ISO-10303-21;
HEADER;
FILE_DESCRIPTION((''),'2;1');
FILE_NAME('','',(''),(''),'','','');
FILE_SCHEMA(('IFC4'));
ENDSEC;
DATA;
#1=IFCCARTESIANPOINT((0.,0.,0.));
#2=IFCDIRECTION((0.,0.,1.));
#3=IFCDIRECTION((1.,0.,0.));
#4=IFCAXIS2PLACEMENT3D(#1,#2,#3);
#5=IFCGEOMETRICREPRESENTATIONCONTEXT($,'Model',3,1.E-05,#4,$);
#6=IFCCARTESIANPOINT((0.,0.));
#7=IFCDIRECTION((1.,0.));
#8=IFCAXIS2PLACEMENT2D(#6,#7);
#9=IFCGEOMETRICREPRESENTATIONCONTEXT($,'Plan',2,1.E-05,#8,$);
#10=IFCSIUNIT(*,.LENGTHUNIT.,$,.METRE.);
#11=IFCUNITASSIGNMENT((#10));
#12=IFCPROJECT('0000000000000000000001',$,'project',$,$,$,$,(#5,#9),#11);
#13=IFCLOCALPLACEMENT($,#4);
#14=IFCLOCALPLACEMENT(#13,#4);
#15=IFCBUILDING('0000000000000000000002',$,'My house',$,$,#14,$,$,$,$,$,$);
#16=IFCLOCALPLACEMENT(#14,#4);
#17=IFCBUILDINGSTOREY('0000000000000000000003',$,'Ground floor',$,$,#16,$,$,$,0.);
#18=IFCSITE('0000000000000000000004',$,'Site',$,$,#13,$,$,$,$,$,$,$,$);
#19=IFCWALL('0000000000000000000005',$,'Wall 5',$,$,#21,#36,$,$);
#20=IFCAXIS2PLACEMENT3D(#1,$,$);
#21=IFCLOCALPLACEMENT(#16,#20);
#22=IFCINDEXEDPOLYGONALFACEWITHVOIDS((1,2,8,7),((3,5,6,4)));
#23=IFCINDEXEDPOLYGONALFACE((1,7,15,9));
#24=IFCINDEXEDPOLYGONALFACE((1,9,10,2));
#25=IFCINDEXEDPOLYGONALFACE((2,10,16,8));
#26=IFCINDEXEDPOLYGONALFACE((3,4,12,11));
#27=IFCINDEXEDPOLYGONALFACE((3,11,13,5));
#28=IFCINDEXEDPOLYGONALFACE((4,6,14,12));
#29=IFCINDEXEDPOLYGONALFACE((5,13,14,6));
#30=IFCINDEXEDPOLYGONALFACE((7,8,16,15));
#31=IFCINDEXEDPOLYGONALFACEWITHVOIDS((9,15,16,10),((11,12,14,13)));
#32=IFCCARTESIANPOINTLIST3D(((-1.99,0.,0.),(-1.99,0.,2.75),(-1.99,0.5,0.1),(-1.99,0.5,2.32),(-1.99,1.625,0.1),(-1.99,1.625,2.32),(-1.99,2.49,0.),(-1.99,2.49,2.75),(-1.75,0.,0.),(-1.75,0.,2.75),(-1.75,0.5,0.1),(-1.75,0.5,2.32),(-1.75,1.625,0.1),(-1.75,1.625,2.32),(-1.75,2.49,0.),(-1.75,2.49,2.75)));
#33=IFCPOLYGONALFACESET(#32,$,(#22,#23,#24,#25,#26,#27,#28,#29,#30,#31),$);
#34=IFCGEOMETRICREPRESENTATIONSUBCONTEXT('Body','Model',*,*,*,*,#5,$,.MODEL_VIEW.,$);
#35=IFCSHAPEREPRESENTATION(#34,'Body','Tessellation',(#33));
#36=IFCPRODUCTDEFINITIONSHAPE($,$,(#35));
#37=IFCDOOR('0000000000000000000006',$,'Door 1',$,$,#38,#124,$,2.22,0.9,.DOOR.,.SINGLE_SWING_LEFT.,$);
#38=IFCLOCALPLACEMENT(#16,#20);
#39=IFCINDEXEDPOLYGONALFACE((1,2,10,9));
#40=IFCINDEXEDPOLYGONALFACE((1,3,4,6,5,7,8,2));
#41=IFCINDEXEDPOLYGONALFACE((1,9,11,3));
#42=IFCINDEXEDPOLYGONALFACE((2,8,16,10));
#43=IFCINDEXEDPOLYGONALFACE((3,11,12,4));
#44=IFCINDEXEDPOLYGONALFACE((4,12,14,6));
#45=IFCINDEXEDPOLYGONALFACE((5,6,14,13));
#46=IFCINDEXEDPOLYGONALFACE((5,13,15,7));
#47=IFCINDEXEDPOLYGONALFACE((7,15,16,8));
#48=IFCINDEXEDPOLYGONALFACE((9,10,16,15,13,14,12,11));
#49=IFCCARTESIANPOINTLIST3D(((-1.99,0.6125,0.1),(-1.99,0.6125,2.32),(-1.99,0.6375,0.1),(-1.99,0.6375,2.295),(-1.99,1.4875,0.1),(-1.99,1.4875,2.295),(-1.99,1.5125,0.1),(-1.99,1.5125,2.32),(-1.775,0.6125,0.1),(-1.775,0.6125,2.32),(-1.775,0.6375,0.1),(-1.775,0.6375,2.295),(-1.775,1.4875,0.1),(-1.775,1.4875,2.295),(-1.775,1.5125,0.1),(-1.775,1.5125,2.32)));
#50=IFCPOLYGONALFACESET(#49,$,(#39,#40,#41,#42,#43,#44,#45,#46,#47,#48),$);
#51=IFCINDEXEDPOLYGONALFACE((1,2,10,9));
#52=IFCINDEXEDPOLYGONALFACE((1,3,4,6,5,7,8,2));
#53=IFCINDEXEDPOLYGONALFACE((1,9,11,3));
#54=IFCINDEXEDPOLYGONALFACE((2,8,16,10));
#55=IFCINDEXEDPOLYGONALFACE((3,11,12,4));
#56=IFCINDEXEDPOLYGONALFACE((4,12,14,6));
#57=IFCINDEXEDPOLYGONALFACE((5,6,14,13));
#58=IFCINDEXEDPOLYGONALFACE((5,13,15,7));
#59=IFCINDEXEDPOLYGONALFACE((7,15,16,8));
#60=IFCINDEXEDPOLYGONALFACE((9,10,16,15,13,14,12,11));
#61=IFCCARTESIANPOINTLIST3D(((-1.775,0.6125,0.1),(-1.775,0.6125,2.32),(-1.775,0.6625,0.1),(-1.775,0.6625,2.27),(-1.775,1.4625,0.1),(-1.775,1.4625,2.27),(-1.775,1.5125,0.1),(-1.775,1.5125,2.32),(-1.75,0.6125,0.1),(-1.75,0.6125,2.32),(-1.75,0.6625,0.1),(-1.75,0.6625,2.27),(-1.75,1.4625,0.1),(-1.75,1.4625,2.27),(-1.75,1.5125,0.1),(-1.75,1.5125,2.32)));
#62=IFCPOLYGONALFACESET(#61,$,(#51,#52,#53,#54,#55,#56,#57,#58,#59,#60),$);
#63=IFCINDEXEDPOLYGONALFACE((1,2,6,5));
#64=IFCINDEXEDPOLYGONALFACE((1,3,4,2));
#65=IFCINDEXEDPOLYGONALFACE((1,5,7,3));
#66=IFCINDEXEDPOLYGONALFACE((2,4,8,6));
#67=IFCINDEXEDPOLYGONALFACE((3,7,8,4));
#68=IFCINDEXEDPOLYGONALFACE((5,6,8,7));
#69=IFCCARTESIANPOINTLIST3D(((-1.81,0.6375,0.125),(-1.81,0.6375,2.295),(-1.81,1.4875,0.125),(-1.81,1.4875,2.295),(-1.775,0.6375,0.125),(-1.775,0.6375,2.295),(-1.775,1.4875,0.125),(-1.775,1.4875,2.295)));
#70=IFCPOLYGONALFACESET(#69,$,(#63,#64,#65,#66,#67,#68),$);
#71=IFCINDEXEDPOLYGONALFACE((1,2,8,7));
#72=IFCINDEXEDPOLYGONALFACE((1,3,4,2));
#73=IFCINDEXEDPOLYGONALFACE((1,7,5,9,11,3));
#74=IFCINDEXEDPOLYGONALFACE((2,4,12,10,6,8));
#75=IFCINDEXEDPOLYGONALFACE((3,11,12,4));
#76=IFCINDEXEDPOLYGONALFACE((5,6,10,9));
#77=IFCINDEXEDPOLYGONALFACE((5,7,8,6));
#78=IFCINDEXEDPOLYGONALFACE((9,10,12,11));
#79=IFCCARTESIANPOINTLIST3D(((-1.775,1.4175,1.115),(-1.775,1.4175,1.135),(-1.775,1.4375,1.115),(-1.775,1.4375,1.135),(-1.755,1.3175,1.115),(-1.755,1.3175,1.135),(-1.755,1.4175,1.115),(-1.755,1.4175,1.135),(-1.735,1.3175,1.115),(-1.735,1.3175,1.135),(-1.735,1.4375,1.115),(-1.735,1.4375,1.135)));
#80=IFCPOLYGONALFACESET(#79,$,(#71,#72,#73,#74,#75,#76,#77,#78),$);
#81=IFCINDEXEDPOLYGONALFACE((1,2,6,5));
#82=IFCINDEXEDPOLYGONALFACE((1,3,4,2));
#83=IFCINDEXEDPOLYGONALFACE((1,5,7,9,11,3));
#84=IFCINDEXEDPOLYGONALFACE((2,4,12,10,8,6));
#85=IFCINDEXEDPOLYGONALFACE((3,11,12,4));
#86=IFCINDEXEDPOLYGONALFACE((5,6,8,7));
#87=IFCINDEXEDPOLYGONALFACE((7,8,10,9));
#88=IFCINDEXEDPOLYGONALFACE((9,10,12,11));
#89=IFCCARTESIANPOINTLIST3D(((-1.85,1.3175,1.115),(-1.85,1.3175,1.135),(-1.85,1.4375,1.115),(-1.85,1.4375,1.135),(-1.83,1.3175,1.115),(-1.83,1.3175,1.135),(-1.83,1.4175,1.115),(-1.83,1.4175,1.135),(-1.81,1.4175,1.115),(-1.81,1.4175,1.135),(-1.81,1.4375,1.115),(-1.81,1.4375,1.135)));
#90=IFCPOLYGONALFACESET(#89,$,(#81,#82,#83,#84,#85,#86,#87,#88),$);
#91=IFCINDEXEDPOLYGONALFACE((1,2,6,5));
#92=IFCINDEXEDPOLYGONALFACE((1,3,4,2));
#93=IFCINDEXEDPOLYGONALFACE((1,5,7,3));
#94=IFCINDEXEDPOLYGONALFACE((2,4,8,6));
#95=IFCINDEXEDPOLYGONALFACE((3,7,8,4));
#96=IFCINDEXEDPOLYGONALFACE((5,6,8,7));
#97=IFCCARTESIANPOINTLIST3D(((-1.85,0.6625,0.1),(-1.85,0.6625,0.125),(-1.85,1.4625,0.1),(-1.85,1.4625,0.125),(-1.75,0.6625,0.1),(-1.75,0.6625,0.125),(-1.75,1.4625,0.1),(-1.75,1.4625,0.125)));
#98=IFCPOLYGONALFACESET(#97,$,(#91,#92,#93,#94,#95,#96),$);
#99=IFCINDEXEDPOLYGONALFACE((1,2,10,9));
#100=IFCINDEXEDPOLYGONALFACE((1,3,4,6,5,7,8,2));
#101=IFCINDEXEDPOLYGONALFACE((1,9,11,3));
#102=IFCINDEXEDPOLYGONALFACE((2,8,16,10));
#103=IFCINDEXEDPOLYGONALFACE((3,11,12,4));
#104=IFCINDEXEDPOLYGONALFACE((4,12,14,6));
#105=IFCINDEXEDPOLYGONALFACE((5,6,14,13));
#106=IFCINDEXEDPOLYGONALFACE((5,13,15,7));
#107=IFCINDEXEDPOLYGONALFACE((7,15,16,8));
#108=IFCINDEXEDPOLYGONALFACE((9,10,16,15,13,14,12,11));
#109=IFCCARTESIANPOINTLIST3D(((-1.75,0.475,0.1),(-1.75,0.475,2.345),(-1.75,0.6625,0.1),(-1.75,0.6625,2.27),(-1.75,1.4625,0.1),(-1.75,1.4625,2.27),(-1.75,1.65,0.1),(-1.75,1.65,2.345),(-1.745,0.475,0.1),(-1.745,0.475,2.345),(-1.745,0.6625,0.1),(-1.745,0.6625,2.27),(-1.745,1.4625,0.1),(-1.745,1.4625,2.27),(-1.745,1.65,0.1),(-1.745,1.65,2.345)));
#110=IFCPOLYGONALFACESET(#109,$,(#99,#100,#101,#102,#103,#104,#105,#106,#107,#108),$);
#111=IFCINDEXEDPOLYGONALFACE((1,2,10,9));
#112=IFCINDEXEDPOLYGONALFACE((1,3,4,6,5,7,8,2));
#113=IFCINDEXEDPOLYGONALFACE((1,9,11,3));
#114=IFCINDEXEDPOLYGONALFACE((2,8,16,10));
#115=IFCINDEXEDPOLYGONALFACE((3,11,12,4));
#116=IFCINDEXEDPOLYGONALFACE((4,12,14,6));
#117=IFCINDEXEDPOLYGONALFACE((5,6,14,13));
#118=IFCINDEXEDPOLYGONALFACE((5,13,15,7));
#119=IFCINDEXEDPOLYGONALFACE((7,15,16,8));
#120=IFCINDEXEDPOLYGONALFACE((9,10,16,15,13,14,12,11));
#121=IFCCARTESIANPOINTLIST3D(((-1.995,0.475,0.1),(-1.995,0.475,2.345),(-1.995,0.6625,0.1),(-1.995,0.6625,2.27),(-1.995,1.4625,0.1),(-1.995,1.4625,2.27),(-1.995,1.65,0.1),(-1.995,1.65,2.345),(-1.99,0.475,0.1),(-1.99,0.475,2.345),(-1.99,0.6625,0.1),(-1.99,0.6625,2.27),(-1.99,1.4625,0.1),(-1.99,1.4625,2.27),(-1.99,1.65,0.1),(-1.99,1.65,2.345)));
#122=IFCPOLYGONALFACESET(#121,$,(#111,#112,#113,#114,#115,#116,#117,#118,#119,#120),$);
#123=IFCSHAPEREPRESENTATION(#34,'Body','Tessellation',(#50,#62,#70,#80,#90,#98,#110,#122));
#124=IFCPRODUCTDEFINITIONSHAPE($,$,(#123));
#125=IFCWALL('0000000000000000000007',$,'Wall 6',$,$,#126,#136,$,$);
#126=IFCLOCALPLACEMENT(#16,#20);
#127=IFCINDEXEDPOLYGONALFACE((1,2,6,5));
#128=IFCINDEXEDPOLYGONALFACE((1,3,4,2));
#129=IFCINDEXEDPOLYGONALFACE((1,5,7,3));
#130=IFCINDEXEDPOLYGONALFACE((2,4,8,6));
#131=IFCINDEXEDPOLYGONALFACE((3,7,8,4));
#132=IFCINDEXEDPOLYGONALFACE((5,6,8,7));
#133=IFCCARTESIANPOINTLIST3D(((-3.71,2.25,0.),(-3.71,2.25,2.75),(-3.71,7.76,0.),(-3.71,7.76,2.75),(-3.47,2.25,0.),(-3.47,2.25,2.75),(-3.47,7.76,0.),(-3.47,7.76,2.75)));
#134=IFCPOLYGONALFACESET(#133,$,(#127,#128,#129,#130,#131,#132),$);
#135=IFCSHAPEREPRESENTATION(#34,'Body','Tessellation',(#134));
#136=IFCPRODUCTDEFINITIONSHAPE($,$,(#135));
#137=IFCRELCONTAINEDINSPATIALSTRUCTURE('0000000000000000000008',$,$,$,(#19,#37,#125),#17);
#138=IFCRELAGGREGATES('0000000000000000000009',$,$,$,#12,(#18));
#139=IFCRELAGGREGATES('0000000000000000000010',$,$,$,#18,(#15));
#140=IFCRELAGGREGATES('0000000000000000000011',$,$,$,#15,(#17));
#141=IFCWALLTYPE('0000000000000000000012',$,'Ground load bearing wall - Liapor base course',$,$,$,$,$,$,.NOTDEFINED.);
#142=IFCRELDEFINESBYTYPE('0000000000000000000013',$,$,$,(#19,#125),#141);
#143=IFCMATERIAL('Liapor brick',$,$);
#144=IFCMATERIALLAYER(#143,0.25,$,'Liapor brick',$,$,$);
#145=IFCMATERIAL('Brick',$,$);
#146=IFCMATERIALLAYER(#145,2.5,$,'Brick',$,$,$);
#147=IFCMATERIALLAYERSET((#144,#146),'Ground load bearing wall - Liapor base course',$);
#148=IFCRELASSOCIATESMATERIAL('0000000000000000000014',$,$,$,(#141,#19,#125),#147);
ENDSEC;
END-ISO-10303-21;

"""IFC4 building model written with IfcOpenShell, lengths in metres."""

from ifc_helpers import new_model, entity, si_unit, frame, origin_with_axes, origin_2d_with_axis, place, context, subcontext, project, spatial, line, indexed_curve, outline, extrude, shape, source, transform, mapped, material, layer, layer_set, layer_usage, type_object, element, fill, save


model = new_model("IFC4")

# Units and contexts
model_context = context("Model", 3, precision=1e-05, world=origin_with_axes())
plan_context = context("Plan", 2, precision=1e-05, world=origin_2d_with_axis())
body_context_1 = subcontext(model_context, "Body", "Model", "MODEL_VIEW")
body_context_2 = subcontext(plan_context, "Body", "Plan", "PLAN_VIEW")
ifc_project = project(units=[si_unit("LENGTHUNIT", "METRE")], contexts=[model_context, plan_context])

# Site, building, storey
site_placement = place(None, origin_with_axes())
site = spatial("IfcSite", under=ifc_project, at=site_placement, Name="Site")
building_placement = place(site_placement, origin_with_axes())
building = spatial("IfcBuilding", under=site, at=building_placement, Name="My house")
storey_placement = place(building_placement, origin_with_axes())
storey = spatial("IfcBuildingStorey", under=building, at=storey_placement, Name="Ground floor", Elevation=0.0)

# Shared definitions
ifc_material_1 = material(Name="Liapor brick")
ifc_layer_1 = layer(ifc_material_1, 0.25, Name="Liapor brick")
ifc_material_2 = material(Name="Brick")
ifc_layer_2 = layer(ifc_material_2, 2.5, Name="Brick")
ifc_layer_set_1 = layer_set([ifc_layer_1, ifc_layer_2], Name="Ground load bearing wall - Liapor base course")
wall_type_1 = type_object("IfcWallType", Name="Ground load bearing wall - Liapor base course", PredefinedType="NOTDEFINED", material=ifc_layer_set_1)

# Wall, opening, door
ifc_layer_usage_1 = layer_usage(ifc_layer_set_1, "AXIS3", "POSITIVE", 0.0)
shared_shape_1 = source(origin_with_axes(), body_context_1, "Body", "SweptSolid", [
    extrude(outline(indexed_curve([(0.0, 0.0), (0.0, 0.24), (2.49, 0.24), (2.49, 0.0), (0.0, 0.0)], self_intersect=False)), origin_with_axes(), (0.0, 0.0, 1.0), 2.75),
])
wall_1_placement = place(storey_placement, frame((-1.75, 2.49, 0.0), z_axis=(0.0, 0.0, 1.0), x_axis=(0.0, 1.0, 0.0)))
wall_1 = element("IfcWall", 1, at=wall_1_placement, inside=storey, type_object=wall_type_1, material=ifc_layer_usage_1, Name="Wall 5", context=body_context_1, shape_type="MappedRepresentation", body=[
    mapped(shared_shape_1, transform((0.0, 0.0, 0.0), x_axis=(-1.0, 0.0, 0.0), y_axis=(0.0, 1.0, 0.0), z_axis=(0.0, 0.0, 1.0), scale=1.0)),
])
shared_shape_2 = source(origin_with_axes(), body_context_1, "Body", "SweptSolid", [
    extrude(outline(indexed_curve([(0.0, 0.0), (0.0, 0.34), (1.125, 0.34), (1.125, 0.0), (0.0, 0.0)], self_intersect=False)), frame((0.0, -0.05, 0.0), z_axis=(0.0, 0.0, 1.0), x_axis=(1.0, 0.0, 0.0)), (0.0, 0.0, 1.0), 2.22),
])
opening_1_placement = place(wall_1_placement, frame((-0.865, 0.0, 0.1), z_axis=(0.0, 0.0, 1.0), x_axis=(1.0, 0.0, 0.0)))
opening_1 = element("IfcOpeningElement", 2, at=opening_1_placement, cuts=wall_1, PredefinedType="OPENING", context=body_context_1, shape_type="MappedRepresentation", body=[
    mapped(shared_shape_2, transform((0.0, 0.0, 0.0), x_axis=(-1.0, 0.0, 0.0), y_axis=(0.0, 1.0, 0.0), z_axis=(0.0, 0.0, 1.0), scale=1.0)),
])
shared_indexed_poly_curve_1 = entity("IfcIndexedPolyCurve", entity("IfcCartesianPointList2D", [[-0.1375, 0.0], [-0.1375, 2.245], [1.0375, 2.245], [1.0375, 0.0], [0.85, 0.0], [0.85, 2.17], [0.05, 2.17], [0.05, 0.0]]), [entity("IfcLineIndex", [1, 2, 3, 4, 5, 6, 7, 8, 1])])
shared_shape_3 = source(origin_with_axes(), body_context_1, "Body", "SweptSolid", [
    extrude(outline(indexed_curve([(0.0, 0.0), (0.0, 2.22), (0.9, 2.22), (0.9, 0.0), (0.875, 0.0), (0.875, 2.195), (0.025, 2.195), (0.025, 0.0)], segments=[line(1, 2, 3, 4, 5, 6, 7, 8, 1)])), frame((0.0, 0.025, 0.0), z_axis=(0.0, -1.0, 0.0), x_axis=(1.0, 0.0, 0.0)), (0.0, 0.0, -1.0), 0.215),
    extrude(outline(indexed_curve([(0.0, 0.0), (0.0, 2.22), (0.9, 2.22), (0.9, 0.0), (0.85, 0.0), (0.85, 2.17), (0.05, 2.17), (0.05, 0.0)], segments=[line(1, 2, 3, 4, 5, 6, 7, 8, 1)])), frame((0.0, 0.0, 0.0), z_axis=(0.0, -1.0, 0.0), x_axis=(1.0, 0.0, 0.0)), (0.0, 0.0, -1.0), 0.025),
    extrude(outline(indexed_curve([(0.0, 0.0), (0.85, 0.0), (0.85, 0.035), (0.0, 0.035)], segments=[line(1, 2, 3, 4, 1)])), frame((0.025, 0.025, 0.025), z_axis=(0.0, 0.0, 1.0), x_axis=(1.0, 0.0, 0.0)), (0.0, 0.0, 1.0), 2.17),
    extrude(outline(indexed_curve([(0.0, 0.0), (0.0, -0.04), (0.12, -0.04), (0.12, -0.02), (0.02, -0.02), (0.02, 0.0)], segments=[line(1, 2, 3, 4, 5, 6, 1)])), frame((0.075, 0.025, 1.015), z_axis=(0.0, 0.0, 1.0), x_axis=(1.0, 0.0, 0.0)), (0.0, 0.0, 1.0), 0.02),
    extrude(outline(indexed_curve([(0.0, 0.0), (0.0, 0.04), (0.12, 0.04), (0.12, 0.02), (0.02, 0.02), (0.02, 0.0)], segments=[line(1, 2, 3, 4, 5, 6, 1)])), frame((0.075, 0.06, 1.015), z_axis=(0.0, 0.0, 1.0), x_axis=(1.0, 0.0, 0.0)), (0.0, 0.0, 1.0), 0.02),
    extrude(outline(indexed_curve([(0.0, 0.0), (0.8, 0.0), (0.8, 0.1), (0.0, 0.1)], segments=[line(1, 2, 3, 4, 1)])), frame((0.05, 0.0, 0.0), z_axis=(0.0, 0.0, 1.0), x_axis=(1.0, 0.0, 0.0)), (0.0, 0.0, 1.0), 0.025),
    entity("IfcExtrudedAreaSolid", entity("IfcArbitraryClosedProfileDef", "AREA", None, shared_indexed_poly_curve_1), entity("IfcAxis2Placement3D", entity("IfcCartesianPoint", [0.0, -0.005, 0.0]), entity("IfcDirection", [0.0, -1.0, 0.0]), entity("IfcDirection", [1.0, 0.0, 0.0])), entity("IfcDirection", [0.0, 0.0, -1.0]), 0.005),
    entity("IfcExtrudedAreaSolid", entity("IfcArbitraryClosedProfileDef", "AREA", None, shared_indexed_poly_curve_1), entity("IfcAxis2Placement3D", entity("IfcCartesianPoint", [0.0, 0.24, 0.0]), entity("IfcDirection", [0.0, -1.0, 0.0]), entity("IfcDirection", [1.0, 0.0, 0.0])), entity("IfcDirection", [0.0, 0.0, -1.0]), 0.005),
])
shared_shape_4 = source(origin_with_axes(), body_context_2, "Body", "Curve2D", [
    entity("IfcIndexedPolyCurve", entity("IfcCartesianPointList2D", [[0.0, 0.0], [0.0, 0.24], [0.025, 0.24], [0.025, 0.025], [0.05, 0.025], [0.05, 0.0]]), [entity("IfcLineIndex", [1, 2, 3, 4, 5, 6, 1])]),
    entity("IfcIndexedPolyCurve", entity("IfcCartesianPointList2D", [[0.9, 0.0], [0.9, 0.24], [0.875, 0.24], [0.875, 0.025], [0.85, 0.025], [0.85, 0.0]]), [entity("IfcLineIndex", [1, 2, 3, 4, 5, 6, 1])]),
    entity("IfcTrimmedCurve", entity("IfcEllipse", entity("IfcAxis2Placement2D", entity("IfcCartesianPoint", [0.84, 0.24]), entity("IfcDirection", [1.0, 0.0])), 0.815, 0.85), [entity("IfcCartesianPoint", [0.84, 1.09])], [entity("IfcCartesianPoint", [0.025, 0.24])], True, "CARTESIAN"),
    entity("IfcIndexedPolyCurve", entity("IfcCartesianPointList2D", [[0.875, 0.24], [0.84, 0.24], [0.84, 1.09], [0.875, 1.09]]), [entity("IfcLineIndex", [1, 2, 3, 4, 1])]),
])
door_1_placement = place(opening_1_placement, frame((-0.1125, 0.0, 0.0), z_axis=(0.0, 0.0, 1.0), x_axis=(1.0, 0.0, 0.0)))
door_1 = element("IfcDoor", 3, at=door_1_placement, inside=storey, Name="Door 1", OperationType="SINGLE_SWING_LEFT", OverallHeight=2.22, OverallWidth=0.9, PredefinedType="DOOR", shapes=[
    shape(body_context_1, "Body", "MappedRepresentation", [mapped(shared_shape_3, transform((0.0, 0.0, 0.0), x_axis=(-1.0, 0.0, 0.0), y_axis=(0.0, 1.0, 0.0), z_axis=(0.0, 0.0, 1.0), scale=1.0))]),
    shape(body_context_2, "Body", "MappedRepresentation", [mapped(shared_shape_4, transform((0.0, 0.0, 0.0), x_axis=(-1.0, 0.0, 0.0), y_axis=(0.0, 1.0, 0.0), z_axis=(0.0, 0.0, 1.0), scale=1.0))]),
])
fill(opening_1, door_1)

# Wall
ifc_layer_usage_2 = layer_usage(ifc_layer_set_1, "AXIS3", "POSITIVE", 0.0)
shared_shape_5 = source(origin_with_axes(), body_context_1, "Body", "SweptSolid", [
    extrude(outline(indexed_curve([(0.0, 0.0), (0.0, 0.24), (5.51, 0.24), (5.51, 0.0)], segments=[line(1, 2, 3, 4, 1)])), origin_with_axes(), (0.0, 0.0, 1.0), 2.75),
])
wall_2_placement = place(storey_placement, frame((-3.71, 2.25, 0.0), z_axis=(0.0, 0.0, 1.0), x_axis=(0.0, -1.0, 0.0)))
element("IfcWall", 4, at=wall_2_placement, inside=storey, type_object=wall_type_1, material=ifc_layer_usage_2, Name="Wall 6", context=body_context_1, shape_type="MappedRepresentation", body=[
    mapped(shared_shape_5, transform((0.0, 0.0, 0.0), x_axis=(-1.0, 0.0, 0.0), y_axis=(0.0, 1.0, 0.0), z_axis=(0.0, 0.0, 1.0), scale=1.0)),
])

save(model, "model.ifc")
